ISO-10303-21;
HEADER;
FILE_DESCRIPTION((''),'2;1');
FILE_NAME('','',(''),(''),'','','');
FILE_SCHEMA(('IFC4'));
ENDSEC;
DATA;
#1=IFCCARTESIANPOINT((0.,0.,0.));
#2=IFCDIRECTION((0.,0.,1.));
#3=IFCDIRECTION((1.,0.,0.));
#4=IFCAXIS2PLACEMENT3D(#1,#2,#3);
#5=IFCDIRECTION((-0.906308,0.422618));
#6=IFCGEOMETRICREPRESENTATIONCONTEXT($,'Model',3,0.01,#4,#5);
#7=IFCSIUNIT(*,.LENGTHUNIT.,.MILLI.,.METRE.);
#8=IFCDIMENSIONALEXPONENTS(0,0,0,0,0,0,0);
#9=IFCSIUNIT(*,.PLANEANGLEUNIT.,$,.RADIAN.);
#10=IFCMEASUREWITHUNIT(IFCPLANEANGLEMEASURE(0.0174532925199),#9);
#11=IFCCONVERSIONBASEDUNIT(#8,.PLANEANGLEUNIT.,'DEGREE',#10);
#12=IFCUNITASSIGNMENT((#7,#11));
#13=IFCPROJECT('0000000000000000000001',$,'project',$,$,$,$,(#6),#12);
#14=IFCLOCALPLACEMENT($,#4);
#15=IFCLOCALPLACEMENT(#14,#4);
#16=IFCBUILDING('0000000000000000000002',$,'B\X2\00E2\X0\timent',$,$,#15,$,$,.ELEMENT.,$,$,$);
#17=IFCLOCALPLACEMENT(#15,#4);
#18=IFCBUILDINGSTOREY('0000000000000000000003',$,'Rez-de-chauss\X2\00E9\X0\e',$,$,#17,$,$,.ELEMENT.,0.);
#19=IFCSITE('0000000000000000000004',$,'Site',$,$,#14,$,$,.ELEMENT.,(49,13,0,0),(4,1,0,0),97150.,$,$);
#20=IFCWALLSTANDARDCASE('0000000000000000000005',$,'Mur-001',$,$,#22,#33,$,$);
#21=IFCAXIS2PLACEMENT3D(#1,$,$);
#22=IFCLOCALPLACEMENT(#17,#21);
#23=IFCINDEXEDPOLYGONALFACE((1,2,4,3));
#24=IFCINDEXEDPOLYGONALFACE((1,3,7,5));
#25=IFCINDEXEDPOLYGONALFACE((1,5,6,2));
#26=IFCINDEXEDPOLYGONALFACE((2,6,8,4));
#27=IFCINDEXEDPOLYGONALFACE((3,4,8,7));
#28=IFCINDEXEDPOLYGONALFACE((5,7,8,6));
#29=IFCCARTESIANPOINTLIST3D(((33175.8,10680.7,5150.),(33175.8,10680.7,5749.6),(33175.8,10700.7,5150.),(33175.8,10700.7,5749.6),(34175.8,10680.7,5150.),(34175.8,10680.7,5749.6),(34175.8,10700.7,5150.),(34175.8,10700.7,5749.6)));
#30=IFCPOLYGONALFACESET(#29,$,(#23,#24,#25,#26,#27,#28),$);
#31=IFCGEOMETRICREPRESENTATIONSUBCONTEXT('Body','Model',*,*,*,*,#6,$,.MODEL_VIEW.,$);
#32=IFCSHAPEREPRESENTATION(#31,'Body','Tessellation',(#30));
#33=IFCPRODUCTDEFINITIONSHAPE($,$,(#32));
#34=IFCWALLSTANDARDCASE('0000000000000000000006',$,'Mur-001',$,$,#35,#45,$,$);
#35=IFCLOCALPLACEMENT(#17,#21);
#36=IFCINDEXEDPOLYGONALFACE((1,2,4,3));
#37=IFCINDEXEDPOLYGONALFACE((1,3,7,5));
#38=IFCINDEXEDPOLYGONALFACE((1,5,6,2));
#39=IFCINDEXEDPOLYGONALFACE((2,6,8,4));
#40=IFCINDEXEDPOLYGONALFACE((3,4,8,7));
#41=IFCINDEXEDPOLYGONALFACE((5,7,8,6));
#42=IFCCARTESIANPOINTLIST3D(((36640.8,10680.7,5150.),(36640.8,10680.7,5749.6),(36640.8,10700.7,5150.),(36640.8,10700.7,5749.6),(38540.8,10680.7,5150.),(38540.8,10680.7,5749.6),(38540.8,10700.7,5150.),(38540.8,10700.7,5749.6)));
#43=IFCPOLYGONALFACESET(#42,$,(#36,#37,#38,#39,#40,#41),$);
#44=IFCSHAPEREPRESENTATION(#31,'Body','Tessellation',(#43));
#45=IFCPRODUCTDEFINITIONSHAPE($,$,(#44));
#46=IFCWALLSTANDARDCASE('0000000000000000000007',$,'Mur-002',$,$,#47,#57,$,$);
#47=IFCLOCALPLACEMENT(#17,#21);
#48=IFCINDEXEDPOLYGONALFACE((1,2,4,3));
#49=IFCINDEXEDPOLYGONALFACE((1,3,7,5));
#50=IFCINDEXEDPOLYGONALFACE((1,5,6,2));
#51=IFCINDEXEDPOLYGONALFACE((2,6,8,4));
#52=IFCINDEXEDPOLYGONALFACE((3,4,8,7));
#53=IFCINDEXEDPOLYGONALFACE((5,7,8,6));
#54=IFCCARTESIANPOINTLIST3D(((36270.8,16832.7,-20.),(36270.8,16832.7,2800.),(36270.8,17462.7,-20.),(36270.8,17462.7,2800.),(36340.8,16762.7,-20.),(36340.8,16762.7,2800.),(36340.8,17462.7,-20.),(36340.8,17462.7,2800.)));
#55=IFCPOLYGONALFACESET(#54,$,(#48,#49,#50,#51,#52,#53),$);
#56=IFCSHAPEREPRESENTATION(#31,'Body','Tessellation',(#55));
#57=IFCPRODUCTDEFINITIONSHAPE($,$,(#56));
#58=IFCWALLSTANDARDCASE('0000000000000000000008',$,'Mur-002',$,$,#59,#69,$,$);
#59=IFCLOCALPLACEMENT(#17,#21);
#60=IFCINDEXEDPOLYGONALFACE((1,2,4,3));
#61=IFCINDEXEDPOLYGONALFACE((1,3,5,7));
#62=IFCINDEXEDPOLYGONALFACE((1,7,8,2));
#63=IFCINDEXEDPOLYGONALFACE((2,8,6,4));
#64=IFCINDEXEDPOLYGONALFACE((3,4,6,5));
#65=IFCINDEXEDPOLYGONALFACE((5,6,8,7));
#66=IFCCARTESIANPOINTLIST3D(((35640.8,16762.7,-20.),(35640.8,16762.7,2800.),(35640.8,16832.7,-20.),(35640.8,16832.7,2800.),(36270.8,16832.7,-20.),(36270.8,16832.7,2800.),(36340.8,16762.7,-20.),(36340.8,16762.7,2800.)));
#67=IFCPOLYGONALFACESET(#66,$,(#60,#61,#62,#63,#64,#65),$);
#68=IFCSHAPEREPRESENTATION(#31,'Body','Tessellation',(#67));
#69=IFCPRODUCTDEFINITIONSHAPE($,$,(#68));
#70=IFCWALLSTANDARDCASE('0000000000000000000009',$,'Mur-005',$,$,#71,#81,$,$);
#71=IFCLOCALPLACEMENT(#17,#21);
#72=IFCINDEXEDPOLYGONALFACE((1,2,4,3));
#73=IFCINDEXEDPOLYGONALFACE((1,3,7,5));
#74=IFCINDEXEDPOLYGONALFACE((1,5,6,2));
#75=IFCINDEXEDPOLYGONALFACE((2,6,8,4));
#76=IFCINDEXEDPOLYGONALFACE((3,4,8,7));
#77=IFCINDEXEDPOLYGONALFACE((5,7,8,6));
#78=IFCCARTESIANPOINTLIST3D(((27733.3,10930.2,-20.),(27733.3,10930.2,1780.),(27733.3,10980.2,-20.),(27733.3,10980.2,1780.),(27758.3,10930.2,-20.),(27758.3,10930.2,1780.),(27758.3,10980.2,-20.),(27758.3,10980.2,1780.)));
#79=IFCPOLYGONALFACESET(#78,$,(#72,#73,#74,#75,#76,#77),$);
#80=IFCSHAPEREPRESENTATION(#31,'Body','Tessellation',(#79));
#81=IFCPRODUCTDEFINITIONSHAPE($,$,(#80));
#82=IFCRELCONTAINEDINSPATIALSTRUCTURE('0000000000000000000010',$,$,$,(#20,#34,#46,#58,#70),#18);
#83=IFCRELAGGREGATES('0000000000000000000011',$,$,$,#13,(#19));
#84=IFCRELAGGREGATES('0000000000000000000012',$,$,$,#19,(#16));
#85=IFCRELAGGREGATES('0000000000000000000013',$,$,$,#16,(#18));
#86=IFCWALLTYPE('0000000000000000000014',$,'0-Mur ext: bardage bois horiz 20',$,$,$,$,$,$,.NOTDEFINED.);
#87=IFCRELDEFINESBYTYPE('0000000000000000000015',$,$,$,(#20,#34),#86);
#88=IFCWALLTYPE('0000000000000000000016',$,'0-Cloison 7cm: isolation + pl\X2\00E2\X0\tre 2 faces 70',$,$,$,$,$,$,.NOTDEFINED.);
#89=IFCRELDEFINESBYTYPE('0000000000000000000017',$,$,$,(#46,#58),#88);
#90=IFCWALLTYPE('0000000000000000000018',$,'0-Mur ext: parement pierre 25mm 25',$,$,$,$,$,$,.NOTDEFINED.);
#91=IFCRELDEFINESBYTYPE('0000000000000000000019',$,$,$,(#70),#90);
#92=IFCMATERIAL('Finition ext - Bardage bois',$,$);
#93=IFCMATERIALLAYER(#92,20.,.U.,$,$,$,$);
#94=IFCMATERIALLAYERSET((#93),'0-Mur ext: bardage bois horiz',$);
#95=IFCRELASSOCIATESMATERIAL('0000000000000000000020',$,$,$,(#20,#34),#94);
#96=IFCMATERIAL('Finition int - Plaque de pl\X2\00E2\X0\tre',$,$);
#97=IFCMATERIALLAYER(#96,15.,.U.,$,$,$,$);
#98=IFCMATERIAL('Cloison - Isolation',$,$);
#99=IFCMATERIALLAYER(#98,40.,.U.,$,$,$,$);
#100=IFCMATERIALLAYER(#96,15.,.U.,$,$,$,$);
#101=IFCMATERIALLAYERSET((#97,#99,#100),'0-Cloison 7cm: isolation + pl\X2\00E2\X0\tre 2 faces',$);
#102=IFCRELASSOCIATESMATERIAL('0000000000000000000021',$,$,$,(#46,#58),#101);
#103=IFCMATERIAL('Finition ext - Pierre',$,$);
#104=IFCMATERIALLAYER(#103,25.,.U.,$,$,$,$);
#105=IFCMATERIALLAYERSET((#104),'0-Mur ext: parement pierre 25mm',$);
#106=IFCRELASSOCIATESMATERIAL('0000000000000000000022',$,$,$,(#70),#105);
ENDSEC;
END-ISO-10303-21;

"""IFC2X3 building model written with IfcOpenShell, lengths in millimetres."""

from ifc_helpers import new_model, entity, si_unit, converted_unit, direction, frame, origin_with_axes, place, context, subcontext, project, spatial, polyline, outline, extrude, material, layer, layer_set, layer_usage, type_object, element, save


model = new_model("IFC2X3")

# Units and contexts
model_context = context("Model", 3, precision=0.01, world=origin_with_axes(), true_north=direction((-0.906308, 0.422618)))
body_context = subcontext(model_context, "Body", "Model", "MODEL_VIEW")
ifc_project = project(units=[si_unit("LENGTHUNIT", "METRE", prefix="MILLI"), converted_unit("PLANEANGLEUNIT", "DEGREE", entity("IfcPlaneAngleMeasure", 0.0174532925199), si_unit("PLANEANGLEUNIT", "RADIAN"), dimensions=[0, 0, 0, 0, 0, 0, 0])], contexts=[model_context])

# Site, building, storey
site_placement = place(None, origin_with_axes())
site = spatial("IfcSite", under=ifc_project, at=site_placement, Name="Site", CompositionType="ELEMENT", RefLatitude=(49, 13, 0, 0), RefLongitude=(4, 1, 0, 0), RefElevation=97150.0)
building_placement = place(site_placement, origin_with_axes())
building = spatial("IfcBuilding", under=site, at=building_placement, Name="Bâtiment", CompositionType="ELEMENT")
storey_placement = place(building_placement, origin_with_axes())
storey = spatial("IfcBuildingStorey", under=building, at=storey_placement, Name="Rez-de-chaussée", CompositionType="ELEMENT", Elevation=0.0)

# Shared definitions
ifc_material_1 = material(Name="Finition int - Plaque de plâtre")
ifc_material_2 = material(Name="Cloison - Isolation")

# Walls
ifc_material_3 = material(Name="Finition ext - Bardage bois")
ifc_layer_1 = layer(ifc_material_3, 20.0, ventilated="UNKNOWN")
ifc_layer_set_1 = layer_set([ifc_layer_1], Name="0-Mur ext: bardage bois horiz")
wall_type_1 = type_object("IfcWallType", Name="0-Mur ext: bardage bois horiz 20", PredefinedType="NOTDEFINED")
ifc_layer_usage_1 = layer_usage(ifc_layer_set_1, "AXIS2", "POSITIVE", 0.0)
wall_1_placement = place(storey_placement, frame((33175.8, 10680.7, 5150.0), z_axis=(0.0, 0.0, 1.0), x_axis=(1.0, 0.0, 0.0)))
element("IfcWallStandardCase", 1, at=wall_1_placement, inside=storey, type_object=wall_type_1, material=ifc_layer_usage_1, Name="Mur-001", context=body_context, shape_type="SweptSolid", body=[
    extrude(outline(polyline([(0.0, 0.0), (1000.0, 0.0), (1000.0, 20.0), (0.0, 20.0), (0.0, 0.0)])), origin_with_axes(), (0.0, 0.0, 1.0), 599.6),
])
ifc_layer_usage_2 = layer_usage(ifc_layer_set_1, "AXIS2", "POSITIVE", 0.0)
wall_2_placement = place(storey_placement, frame((36640.8, 10680.7, 5150.0), z_axis=(0.0, 0.0, 1.0), x_axis=(1.0, 0.0, 0.0)))
element("IfcWallStandardCase", 2, at=wall_2_placement, inside=storey, type_object=wall_type_1, material=ifc_layer_usage_2, Name="Mur-001", context=body_context, shape_type="SweptSolid", body=[
    extrude(outline(polyline([(0.0, 0.0), (1900.0, 0.0), (1900.0, 20.0), (0.0, 20.0), (0.0, 0.0)])), origin_with_axes(), (0.0, 0.0, 1.0), 599.6),
])
ifc_layer_2 = layer(ifc_material_1, 15.0, ventilated="UNKNOWN")
ifc_layer_3 = layer(ifc_material_2, 40.0, ventilated="UNKNOWN")
ifc_layer_4 = layer(ifc_material_1, 15.0, ventilated="UNKNOWN")
ifc_layer_set_2 = layer_set([ifc_layer_2, ifc_layer_3, ifc_layer_4], Name="0-Cloison 7cm: isolation + plâtre 2 faces")
ifc_layer_usage_3 = layer_usage(ifc_layer_set_2, "AXIS2", "POSITIVE", 0.0)
wall_type_2 = type_object("IfcWallType", Name="0-Cloison 7cm: isolation + plâtre 2 faces 70", PredefinedType="NOTDEFINED")
wall_3_placement = place(storey_placement, frame((36340.8, 16762.7, -20.0), z_axis=(0.0, 0.0, 1.0), x_axis=(0.0, 1.0, 0.0)))
element("IfcWallStandardCase", 3, at=wall_3_placement, inside=storey, type_object=wall_type_2, material=ifc_layer_usage_3, Name="Mur-002", context=body_context, shape_type="SweptSolid", body=[
    extrude(outline(polyline([(0.0, 0.0), (700.0, 0.0), (700.0, 70.0), (70.0, 70.0), (0.0, 0.0)])), origin_with_axes(), (0.0, 0.0, 1.0), 2820.0),
])
ifc_layer_usage_4 = layer_usage(ifc_layer_set_2, "AXIS2", "POSITIVE", -70.0)
wall_4_placement = place(storey_placement, frame((36340.8, 16762.7, -20.0), z_axis=(0.0, 0.0, 1.0), x_axis=(-1.0, 0.0, 0.0)))
element("IfcWallStandardCase", 4, at=wall_4_placement, inside=storey, type_object=wall_type_2, material=ifc_layer_usage_4, Name="Mur-002", context=body_context, shape_type="SweptSolid", body=[
    extrude(outline(polyline([(70.0, -70.0), (700.0, -70.0), (700.0, 0.0), (0.0, 0.0), (70.0, -70.0)])), origin_with_axes(), (0.0, 0.0, 1.0), 2820.0),
])
ifc_material_4 = material(Name="Finition ext - Pierre")
ifc_layer_5 = layer(ifc_material_4, 25.0, ventilated="UNKNOWN")
ifc_layer_set_3 = layer_set([ifc_layer_5], Name="0-Mur ext: parement pierre 25mm")
ifc_layer_usage_5 = layer_usage(ifc_layer_set_3, "AXIS2", "POSITIVE", 0.0)
wall_type_3 = type_object("IfcWallType", Name="0-Mur ext: parement pierre 25mm 25", PredefinedType="NOTDEFINED")
wall_5_placement = place(storey_placement, frame((27758.3, 10930.2, -20.0), z_axis=(0.0, 0.0, 1.0), x_axis=(0.0, 1.0, 0.0)))
element("IfcWallStandardCase", 5, at=wall_5_placement, inside=storey, type_object=wall_type_3, material=ifc_layer_usage_5, Name="Mur-005", context=body_context, shape_type="SweptSolid", body=[
    extrude(outline(polyline([(0.0, 0.0), (50.0, 0.0), (50.0, 25.0), (0.0, 25.0), (0.0, 0.0)])), origin_with_axes(), (0.0, 0.0, 1.0), 1800.0),
])

save(model, "model.ifc")
